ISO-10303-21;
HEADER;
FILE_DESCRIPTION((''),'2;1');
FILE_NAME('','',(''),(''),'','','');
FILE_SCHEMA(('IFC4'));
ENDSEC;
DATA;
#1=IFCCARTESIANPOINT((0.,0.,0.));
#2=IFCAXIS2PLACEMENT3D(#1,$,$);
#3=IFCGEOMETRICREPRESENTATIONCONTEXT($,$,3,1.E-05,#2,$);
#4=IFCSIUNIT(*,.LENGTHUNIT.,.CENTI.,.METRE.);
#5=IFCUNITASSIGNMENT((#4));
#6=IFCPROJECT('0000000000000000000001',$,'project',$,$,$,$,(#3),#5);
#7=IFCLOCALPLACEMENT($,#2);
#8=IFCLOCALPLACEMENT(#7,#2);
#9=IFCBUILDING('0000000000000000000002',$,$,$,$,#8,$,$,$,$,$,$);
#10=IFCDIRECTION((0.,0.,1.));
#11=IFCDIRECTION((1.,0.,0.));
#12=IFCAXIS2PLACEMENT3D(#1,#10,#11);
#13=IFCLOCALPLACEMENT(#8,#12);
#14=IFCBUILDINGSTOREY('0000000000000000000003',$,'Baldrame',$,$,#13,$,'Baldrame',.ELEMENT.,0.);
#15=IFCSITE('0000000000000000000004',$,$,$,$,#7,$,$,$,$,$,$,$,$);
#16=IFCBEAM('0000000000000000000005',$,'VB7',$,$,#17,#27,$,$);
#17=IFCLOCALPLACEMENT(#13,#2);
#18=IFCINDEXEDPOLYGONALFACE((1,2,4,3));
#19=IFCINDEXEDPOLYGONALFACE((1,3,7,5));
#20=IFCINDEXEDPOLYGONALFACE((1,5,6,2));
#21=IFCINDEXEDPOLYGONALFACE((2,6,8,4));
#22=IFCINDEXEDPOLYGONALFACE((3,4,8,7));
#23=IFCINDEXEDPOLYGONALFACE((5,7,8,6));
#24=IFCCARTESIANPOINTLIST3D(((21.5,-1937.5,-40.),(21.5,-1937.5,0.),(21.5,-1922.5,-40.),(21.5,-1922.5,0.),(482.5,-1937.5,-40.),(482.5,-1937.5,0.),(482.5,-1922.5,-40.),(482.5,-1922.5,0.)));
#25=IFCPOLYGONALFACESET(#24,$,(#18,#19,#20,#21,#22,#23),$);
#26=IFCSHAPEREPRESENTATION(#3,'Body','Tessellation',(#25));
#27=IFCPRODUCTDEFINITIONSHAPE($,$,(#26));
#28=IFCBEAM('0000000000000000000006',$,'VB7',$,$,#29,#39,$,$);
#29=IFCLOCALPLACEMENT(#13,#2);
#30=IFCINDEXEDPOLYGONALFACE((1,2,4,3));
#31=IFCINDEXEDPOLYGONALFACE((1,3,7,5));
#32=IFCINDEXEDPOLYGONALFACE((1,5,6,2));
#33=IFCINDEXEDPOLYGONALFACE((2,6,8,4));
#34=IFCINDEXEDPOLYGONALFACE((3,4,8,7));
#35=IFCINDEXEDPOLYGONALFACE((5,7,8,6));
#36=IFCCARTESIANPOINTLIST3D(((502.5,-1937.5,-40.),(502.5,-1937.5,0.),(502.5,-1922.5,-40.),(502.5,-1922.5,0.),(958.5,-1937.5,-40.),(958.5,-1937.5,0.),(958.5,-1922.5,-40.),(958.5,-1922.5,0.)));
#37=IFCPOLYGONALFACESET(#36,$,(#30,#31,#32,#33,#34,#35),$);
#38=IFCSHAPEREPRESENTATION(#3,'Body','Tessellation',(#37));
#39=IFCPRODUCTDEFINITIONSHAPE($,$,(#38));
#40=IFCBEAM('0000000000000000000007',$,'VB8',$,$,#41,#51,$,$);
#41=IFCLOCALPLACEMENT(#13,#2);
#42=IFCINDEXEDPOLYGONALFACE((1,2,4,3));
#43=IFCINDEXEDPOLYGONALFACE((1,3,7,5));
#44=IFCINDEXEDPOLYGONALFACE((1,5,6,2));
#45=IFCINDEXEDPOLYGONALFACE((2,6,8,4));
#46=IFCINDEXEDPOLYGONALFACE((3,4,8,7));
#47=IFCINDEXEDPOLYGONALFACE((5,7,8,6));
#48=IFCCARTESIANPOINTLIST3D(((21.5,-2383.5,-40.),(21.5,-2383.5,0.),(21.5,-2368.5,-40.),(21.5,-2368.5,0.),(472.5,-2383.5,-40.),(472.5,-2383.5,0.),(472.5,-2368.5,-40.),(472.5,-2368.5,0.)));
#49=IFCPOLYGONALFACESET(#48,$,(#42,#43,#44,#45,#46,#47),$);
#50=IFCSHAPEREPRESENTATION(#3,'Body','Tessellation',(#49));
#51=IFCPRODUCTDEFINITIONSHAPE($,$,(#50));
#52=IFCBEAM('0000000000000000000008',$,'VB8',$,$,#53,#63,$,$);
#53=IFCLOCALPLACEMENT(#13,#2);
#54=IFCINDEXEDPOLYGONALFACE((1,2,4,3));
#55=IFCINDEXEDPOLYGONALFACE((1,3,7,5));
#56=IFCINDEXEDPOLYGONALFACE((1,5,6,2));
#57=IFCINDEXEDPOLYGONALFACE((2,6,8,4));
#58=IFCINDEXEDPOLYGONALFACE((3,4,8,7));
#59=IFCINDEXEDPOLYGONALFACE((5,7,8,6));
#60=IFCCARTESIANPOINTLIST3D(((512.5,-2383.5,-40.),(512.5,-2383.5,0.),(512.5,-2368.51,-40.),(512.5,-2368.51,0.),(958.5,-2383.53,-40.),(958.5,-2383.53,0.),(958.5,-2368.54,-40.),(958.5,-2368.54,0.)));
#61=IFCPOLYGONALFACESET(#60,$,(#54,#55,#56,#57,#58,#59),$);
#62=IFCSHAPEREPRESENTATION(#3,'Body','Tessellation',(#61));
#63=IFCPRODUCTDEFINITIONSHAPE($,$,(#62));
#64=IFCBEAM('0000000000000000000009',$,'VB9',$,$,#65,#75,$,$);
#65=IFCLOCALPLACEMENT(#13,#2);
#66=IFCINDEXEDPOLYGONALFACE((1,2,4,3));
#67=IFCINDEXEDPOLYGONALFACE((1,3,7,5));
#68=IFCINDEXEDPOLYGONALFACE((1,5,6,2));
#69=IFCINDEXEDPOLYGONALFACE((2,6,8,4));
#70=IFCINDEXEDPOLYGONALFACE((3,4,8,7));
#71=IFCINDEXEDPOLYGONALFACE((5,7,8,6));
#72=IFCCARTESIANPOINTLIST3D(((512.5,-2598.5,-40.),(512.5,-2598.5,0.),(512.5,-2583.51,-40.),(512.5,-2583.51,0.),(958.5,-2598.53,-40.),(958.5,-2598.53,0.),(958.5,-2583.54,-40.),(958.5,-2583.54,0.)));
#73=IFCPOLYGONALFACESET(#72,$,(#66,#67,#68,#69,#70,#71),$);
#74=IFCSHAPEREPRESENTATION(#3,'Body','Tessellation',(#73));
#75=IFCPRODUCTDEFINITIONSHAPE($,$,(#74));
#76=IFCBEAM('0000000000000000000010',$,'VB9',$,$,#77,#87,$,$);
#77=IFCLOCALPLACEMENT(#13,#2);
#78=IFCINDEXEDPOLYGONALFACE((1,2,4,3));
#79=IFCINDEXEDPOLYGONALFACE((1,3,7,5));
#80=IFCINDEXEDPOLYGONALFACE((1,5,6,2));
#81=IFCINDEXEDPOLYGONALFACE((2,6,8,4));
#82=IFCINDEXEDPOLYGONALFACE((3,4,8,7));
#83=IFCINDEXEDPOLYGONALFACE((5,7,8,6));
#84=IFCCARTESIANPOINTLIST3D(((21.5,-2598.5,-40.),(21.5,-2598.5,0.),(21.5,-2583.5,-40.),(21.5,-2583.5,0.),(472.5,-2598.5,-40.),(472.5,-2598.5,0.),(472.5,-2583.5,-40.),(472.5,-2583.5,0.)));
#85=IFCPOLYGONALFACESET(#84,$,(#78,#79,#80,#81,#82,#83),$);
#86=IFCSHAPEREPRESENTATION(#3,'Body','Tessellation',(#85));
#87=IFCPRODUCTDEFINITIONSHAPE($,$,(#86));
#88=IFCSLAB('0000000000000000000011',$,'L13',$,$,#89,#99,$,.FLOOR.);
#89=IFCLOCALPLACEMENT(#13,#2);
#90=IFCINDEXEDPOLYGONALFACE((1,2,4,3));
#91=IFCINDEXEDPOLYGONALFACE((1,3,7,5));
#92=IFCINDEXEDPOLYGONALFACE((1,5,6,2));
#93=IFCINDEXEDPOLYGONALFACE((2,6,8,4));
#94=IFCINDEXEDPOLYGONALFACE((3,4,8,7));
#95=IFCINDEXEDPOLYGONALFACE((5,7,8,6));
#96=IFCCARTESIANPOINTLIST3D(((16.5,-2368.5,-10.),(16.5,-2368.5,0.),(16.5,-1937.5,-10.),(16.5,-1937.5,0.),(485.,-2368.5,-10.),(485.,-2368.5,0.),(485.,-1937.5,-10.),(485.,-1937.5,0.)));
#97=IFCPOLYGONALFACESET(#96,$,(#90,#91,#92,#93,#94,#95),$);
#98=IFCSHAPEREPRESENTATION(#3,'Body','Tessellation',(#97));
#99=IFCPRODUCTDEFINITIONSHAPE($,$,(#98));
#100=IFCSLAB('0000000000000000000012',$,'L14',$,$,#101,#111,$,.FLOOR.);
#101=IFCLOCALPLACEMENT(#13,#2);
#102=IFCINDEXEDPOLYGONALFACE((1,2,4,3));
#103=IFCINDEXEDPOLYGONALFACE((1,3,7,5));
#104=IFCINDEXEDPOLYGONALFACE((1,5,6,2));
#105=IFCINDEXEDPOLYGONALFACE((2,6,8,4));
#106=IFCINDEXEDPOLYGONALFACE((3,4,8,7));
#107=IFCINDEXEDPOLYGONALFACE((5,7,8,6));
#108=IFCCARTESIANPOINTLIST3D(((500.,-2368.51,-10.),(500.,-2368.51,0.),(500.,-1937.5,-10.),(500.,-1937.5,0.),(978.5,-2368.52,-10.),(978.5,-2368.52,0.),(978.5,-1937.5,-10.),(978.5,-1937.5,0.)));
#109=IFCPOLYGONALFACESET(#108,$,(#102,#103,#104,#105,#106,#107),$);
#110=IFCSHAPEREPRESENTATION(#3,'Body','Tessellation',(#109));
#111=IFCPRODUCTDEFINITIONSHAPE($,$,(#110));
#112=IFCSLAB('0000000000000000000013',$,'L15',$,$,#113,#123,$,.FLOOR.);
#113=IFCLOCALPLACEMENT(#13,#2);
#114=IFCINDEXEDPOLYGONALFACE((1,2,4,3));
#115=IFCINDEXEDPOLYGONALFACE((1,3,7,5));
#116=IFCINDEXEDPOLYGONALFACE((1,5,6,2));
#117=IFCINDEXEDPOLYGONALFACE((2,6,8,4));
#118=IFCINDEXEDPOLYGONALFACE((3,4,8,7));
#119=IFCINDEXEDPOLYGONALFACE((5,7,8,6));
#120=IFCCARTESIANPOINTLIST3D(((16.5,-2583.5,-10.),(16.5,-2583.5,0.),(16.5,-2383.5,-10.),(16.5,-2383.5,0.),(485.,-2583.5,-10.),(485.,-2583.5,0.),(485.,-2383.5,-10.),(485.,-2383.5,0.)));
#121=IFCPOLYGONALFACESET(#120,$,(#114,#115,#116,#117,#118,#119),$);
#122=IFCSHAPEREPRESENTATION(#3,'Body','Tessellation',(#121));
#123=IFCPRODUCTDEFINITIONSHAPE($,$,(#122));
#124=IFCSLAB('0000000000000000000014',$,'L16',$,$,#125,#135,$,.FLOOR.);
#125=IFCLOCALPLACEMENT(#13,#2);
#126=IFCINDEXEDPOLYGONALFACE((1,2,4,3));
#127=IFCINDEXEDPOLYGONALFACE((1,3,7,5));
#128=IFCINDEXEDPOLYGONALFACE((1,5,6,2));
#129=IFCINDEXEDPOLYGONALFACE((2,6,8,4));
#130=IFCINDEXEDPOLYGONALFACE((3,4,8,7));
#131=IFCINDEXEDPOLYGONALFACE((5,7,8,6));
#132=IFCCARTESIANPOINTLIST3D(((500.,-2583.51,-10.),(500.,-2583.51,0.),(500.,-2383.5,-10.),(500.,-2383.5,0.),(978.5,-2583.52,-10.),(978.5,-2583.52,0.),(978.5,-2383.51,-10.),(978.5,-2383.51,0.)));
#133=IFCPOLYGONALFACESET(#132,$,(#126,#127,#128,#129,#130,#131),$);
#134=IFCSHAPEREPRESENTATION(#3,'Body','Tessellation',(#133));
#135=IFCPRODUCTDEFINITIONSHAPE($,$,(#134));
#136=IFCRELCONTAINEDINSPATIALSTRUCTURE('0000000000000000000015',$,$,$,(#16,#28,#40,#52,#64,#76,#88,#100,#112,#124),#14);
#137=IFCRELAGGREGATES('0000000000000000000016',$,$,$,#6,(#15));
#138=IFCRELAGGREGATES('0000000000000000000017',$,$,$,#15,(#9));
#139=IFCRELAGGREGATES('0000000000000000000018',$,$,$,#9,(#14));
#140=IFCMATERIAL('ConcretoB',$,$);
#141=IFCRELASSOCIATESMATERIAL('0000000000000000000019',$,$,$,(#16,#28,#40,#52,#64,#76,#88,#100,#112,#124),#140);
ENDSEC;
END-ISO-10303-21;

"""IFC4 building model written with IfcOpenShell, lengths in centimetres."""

from ifc_helpers import new_model, si_unit, frame, origin, origin_with_axes, place, context, project, spatial, polyline, outline, extrude, material, element, save


model = new_model("IFC4")

# Units and contexts
context_of_model = context(None, 3, precision=1e-05, world=origin())
ifc_project = project(units=[si_unit("LENGTHUNIT", "METRE", prefix="CENTI")], contexts=[context_of_model])

# Site, building, storey
site_placement = place(None, origin())
site = spatial("IfcSite", under=ifc_project, at=site_placement)
building_placement = place(site_placement, origin())
building = spatial("IfcBuilding", under=site, at=building_placement)
storey_placement = place(building_placement, origin_with_axes())
storey = spatial("IfcBuildingStorey", under=building, at=storey_placement, Name="Baldrame", LongName="Baldrame", CompositionType="ELEMENT", Elevation=0.0)

# Shared definitions
ifc_material = material(Name="ConcretoB")

# Beams
beam_1_placement = place(storey_placement, frame((252.0, -1930.0, 0.0), z_axis=(0.0, 0.0, 1.0), x_axis=(1.0, 0.0, 0.0)))
element("IfcBeam", 1, at=beam_1_placement, inside=storey, material=ifc_material, Name="VB7", context=context_of_model, shape_type="SolidModel", body=[
    extrude(outline(polyline([(-7.5, -20.0), (7.5, -20.0), (7.5, 20.0), (-7.5, 20.0), (-7.5, -20.0)])), frame((-230.5, 0.0, -20.0), z_axis=(1.0, 0.0, 0.0), x_axis=(0.0, -1.0, 0.0)), (0.0, 0.0, 1.0), 461.0),
])
beam_2_placement = place(storey_placement, frame((730.5, -1930.0, 0.0), z_axis=(0.0, 0.0, 1.0), x_axis=(1.0, 0.0, 0.0)))
element("IfcBeam", 2, at=beam_2_placement, inside=storey, material=ifc_material, Name="VB7", context=context_of_model, shape_type="SolidModel", body=[
    extrude(outline(polyline([(-7.5, -20.0), (7.5, -20.0), (7.5, 20.0), (-7.5, 20.0), (-7.5, -20.0)])), frame((-228.0, 0.0, -20.0), z_axis=(1.0, 0.0, 0.0), x_axis=(0.0, -1.0, 0.0)), (0.0, 0.0, 1.0), 456.0),
])
beam_3_placement = place(storey_placement, frame((247.0, -2376.0, 0.0), z_axis=(0.0, 0.0, 1.0), x_axis=(1.0, 0.0, 0.0)))
element("IfcBeam", 3, at=beam_3_placement, inside=storey, material=ifc_material, Name="VB8", context=context_of_model, shape_type="SolidModel", body=[
    extrude(outline(polyline([(-7.5, -20.0), (7.5, -20.0), (7.5, 20.0), (-7.5, 20.0), (-7.5, -20.0)])), frame((-225.5, 0.0, -20.0), z_axis=(1.0, 0.0, 0.0), x_axis=(0.0, -1.0, 0.0)), (0.0, 0.0, 1.0), 451.0),
])
for number, where, z_axis, x_axis, name in (
    (4, (735.5, -2376.02, 0.0), (0.0, 0.0, 1.0), (1.0, 0.0, 0.0), "VB8"),
    (5, (735.5, -2591.02, 0.0), (0.0, 0.0, 1.0), (1.0, 0.0, 0.0), "VB9"),
):
    element("IfcBeam", number, at=place(storey_placement, frame(where, z_axis=z_axis, x_axis=x_axis)), inside=storey, material=ifc_material, Name=name, context=context_of_model, shape_type="SolidModel", body=[
        extrude(outline(polyline([(-7.5, -20.0), (7.5, -20.0), (7.5, 20.0), (-7.5, 20.0), (-7.5, -20.0)])), frame((-223.0, 0.01, -20.0), z_axis=(1.0, -0.000067, 0.0), x_axis=(-0.000067, -1.0, 0.0)), (0.0, 0.0, 1.0), 446.0),
    ])
beam_4_placement = place(storey_placement, frame((247.0, -2591.0, 0.0), z_axis=(0.0, 0.0, 1.0), x_axis=(1.0, 0.0, 0.0)))
element("IfcBeam", 6, at=beam_4_placement, inside=storey, material=ifc_material, Name="VB9", context=context_of_model, shape_type="SolidModel", body=[
    extrude(outline(polyline([(-7.5, -20.0), (7.5, -20.0), (7.5, 20.0), (-7.5, 20.0), (-7.5, -20.0)])), frame((-225.5, 0.0, -20.0), z_axis=(1.0, 0.0, 0.0), x_axis=(0.0, -1.0, 0.0)), (0.0, 0.0, 1.0), 451.0),
])

# Slabs
slab_1_placement = place(storey_placement, frame((250.75, -2153.0, 0.0), z_axis=(0.0, 0.0, 1.0), x_axis=(1.0, 0.0, 0.0)))
element("IfcSlab", 7, at=slab_1_placement, inside=storey, material=ifc_material, Name="L13", PredefinedType="FLOOR", context=context_of_model, shape_type="SolidModel", body=[
    extrude(outline(polyline([(234.25, 215.5), (-234.25, 215.5), (-234.25, -215.5), (234.25, -215.5), (234.25, 215.5), (234.25, 215.5)])), frame((0.0, 0.0, -10.0), z_axis=(0.0, 0.0, 1.0), x_axis=(1.0, 0.0, 0.0)), (0.0, 0.0, 1.0), 10.0),
])
slab_2_placement = place(storey_placement, frame((739.25, -2153.01, 0.0), z_axis=(0.0, 0.0, 1.0), x_axis=(1.0, 0.0, 0.0)))
element("IfcSlab", 8, at=slab_2_placement, inside=storey, material=ifc_material, Name="L14", PredefinedType="FLOOR", context=context_of_model, shape_type="SolidModel", body=[
    extrude(outline(polyline([(239.25, 215.52), (-239.25, 215.52), (-239.25, -215.5), (239.25, -215.51), (239.25, 215.52), (239.25, 215.52)])), frame((0.0, 0.0, -10.0), z_axis=(0.0, 0.0, 1.0), x_axis=(1.0, 0.0, 0.0)), (0.0, 0.0, 1.0), 10.0),
])
slab_3_placement = place(storey_placement, frame((250.75, -2483.5, 0.0), z_axis=(0.0, 0.0, 1.0), x_axis=(1.0, 0.0, 0.0)))
element("IfcSlab", 9, at=slab_3_placement, inside=storey, material=ifc_material, Name="L15", PredefinedType="FLOOR", context=context_of_model, shape_type="SolidModel", body=[
    extrude(outline(polyline([(234.25, 100.0), (-234.25, 100.0), (-234.25, -100.0), (234.25, -100.0), (234.25, 100.0), (234.25, 100.0)])), frame((0.0, 0.0, -10.0), z_axis=(0.0, 0.0, 1.0), x_axis=(1.0, 0.0, 0.0)), (0.0, 0.0, 1.0), 10.0),
])
slab_4_placement = place(storey_placement, frame((739.25, -2483.51, 0.0), z_axis=(0.0, 0.0, 1.0), x_axis=(1.0, 0.0, 0.0)))
element("IfcSlab", 10, at=slab_4_placement, inside=storey, material=ifc_material, Name="L16", PredefinedType="FLOOR", context=context_of_model, shape_type="SolidModel", body=[
    extrude(outline(polyline([(239.25, 100.0), (-239.25, 100.01), (-239.25, -100.0), (239.25, -100.01), (239.25, 100.0), (239.25, 100.0)])), frame((0.0, 0.0, -10.0), z_axis=(0.0, 0.0, 1.0), x_axis=(1.0, 0.0, 0.0)), (0.0, 0.0, 1.0), 10.0),
])

save(model, "model.ifc")
